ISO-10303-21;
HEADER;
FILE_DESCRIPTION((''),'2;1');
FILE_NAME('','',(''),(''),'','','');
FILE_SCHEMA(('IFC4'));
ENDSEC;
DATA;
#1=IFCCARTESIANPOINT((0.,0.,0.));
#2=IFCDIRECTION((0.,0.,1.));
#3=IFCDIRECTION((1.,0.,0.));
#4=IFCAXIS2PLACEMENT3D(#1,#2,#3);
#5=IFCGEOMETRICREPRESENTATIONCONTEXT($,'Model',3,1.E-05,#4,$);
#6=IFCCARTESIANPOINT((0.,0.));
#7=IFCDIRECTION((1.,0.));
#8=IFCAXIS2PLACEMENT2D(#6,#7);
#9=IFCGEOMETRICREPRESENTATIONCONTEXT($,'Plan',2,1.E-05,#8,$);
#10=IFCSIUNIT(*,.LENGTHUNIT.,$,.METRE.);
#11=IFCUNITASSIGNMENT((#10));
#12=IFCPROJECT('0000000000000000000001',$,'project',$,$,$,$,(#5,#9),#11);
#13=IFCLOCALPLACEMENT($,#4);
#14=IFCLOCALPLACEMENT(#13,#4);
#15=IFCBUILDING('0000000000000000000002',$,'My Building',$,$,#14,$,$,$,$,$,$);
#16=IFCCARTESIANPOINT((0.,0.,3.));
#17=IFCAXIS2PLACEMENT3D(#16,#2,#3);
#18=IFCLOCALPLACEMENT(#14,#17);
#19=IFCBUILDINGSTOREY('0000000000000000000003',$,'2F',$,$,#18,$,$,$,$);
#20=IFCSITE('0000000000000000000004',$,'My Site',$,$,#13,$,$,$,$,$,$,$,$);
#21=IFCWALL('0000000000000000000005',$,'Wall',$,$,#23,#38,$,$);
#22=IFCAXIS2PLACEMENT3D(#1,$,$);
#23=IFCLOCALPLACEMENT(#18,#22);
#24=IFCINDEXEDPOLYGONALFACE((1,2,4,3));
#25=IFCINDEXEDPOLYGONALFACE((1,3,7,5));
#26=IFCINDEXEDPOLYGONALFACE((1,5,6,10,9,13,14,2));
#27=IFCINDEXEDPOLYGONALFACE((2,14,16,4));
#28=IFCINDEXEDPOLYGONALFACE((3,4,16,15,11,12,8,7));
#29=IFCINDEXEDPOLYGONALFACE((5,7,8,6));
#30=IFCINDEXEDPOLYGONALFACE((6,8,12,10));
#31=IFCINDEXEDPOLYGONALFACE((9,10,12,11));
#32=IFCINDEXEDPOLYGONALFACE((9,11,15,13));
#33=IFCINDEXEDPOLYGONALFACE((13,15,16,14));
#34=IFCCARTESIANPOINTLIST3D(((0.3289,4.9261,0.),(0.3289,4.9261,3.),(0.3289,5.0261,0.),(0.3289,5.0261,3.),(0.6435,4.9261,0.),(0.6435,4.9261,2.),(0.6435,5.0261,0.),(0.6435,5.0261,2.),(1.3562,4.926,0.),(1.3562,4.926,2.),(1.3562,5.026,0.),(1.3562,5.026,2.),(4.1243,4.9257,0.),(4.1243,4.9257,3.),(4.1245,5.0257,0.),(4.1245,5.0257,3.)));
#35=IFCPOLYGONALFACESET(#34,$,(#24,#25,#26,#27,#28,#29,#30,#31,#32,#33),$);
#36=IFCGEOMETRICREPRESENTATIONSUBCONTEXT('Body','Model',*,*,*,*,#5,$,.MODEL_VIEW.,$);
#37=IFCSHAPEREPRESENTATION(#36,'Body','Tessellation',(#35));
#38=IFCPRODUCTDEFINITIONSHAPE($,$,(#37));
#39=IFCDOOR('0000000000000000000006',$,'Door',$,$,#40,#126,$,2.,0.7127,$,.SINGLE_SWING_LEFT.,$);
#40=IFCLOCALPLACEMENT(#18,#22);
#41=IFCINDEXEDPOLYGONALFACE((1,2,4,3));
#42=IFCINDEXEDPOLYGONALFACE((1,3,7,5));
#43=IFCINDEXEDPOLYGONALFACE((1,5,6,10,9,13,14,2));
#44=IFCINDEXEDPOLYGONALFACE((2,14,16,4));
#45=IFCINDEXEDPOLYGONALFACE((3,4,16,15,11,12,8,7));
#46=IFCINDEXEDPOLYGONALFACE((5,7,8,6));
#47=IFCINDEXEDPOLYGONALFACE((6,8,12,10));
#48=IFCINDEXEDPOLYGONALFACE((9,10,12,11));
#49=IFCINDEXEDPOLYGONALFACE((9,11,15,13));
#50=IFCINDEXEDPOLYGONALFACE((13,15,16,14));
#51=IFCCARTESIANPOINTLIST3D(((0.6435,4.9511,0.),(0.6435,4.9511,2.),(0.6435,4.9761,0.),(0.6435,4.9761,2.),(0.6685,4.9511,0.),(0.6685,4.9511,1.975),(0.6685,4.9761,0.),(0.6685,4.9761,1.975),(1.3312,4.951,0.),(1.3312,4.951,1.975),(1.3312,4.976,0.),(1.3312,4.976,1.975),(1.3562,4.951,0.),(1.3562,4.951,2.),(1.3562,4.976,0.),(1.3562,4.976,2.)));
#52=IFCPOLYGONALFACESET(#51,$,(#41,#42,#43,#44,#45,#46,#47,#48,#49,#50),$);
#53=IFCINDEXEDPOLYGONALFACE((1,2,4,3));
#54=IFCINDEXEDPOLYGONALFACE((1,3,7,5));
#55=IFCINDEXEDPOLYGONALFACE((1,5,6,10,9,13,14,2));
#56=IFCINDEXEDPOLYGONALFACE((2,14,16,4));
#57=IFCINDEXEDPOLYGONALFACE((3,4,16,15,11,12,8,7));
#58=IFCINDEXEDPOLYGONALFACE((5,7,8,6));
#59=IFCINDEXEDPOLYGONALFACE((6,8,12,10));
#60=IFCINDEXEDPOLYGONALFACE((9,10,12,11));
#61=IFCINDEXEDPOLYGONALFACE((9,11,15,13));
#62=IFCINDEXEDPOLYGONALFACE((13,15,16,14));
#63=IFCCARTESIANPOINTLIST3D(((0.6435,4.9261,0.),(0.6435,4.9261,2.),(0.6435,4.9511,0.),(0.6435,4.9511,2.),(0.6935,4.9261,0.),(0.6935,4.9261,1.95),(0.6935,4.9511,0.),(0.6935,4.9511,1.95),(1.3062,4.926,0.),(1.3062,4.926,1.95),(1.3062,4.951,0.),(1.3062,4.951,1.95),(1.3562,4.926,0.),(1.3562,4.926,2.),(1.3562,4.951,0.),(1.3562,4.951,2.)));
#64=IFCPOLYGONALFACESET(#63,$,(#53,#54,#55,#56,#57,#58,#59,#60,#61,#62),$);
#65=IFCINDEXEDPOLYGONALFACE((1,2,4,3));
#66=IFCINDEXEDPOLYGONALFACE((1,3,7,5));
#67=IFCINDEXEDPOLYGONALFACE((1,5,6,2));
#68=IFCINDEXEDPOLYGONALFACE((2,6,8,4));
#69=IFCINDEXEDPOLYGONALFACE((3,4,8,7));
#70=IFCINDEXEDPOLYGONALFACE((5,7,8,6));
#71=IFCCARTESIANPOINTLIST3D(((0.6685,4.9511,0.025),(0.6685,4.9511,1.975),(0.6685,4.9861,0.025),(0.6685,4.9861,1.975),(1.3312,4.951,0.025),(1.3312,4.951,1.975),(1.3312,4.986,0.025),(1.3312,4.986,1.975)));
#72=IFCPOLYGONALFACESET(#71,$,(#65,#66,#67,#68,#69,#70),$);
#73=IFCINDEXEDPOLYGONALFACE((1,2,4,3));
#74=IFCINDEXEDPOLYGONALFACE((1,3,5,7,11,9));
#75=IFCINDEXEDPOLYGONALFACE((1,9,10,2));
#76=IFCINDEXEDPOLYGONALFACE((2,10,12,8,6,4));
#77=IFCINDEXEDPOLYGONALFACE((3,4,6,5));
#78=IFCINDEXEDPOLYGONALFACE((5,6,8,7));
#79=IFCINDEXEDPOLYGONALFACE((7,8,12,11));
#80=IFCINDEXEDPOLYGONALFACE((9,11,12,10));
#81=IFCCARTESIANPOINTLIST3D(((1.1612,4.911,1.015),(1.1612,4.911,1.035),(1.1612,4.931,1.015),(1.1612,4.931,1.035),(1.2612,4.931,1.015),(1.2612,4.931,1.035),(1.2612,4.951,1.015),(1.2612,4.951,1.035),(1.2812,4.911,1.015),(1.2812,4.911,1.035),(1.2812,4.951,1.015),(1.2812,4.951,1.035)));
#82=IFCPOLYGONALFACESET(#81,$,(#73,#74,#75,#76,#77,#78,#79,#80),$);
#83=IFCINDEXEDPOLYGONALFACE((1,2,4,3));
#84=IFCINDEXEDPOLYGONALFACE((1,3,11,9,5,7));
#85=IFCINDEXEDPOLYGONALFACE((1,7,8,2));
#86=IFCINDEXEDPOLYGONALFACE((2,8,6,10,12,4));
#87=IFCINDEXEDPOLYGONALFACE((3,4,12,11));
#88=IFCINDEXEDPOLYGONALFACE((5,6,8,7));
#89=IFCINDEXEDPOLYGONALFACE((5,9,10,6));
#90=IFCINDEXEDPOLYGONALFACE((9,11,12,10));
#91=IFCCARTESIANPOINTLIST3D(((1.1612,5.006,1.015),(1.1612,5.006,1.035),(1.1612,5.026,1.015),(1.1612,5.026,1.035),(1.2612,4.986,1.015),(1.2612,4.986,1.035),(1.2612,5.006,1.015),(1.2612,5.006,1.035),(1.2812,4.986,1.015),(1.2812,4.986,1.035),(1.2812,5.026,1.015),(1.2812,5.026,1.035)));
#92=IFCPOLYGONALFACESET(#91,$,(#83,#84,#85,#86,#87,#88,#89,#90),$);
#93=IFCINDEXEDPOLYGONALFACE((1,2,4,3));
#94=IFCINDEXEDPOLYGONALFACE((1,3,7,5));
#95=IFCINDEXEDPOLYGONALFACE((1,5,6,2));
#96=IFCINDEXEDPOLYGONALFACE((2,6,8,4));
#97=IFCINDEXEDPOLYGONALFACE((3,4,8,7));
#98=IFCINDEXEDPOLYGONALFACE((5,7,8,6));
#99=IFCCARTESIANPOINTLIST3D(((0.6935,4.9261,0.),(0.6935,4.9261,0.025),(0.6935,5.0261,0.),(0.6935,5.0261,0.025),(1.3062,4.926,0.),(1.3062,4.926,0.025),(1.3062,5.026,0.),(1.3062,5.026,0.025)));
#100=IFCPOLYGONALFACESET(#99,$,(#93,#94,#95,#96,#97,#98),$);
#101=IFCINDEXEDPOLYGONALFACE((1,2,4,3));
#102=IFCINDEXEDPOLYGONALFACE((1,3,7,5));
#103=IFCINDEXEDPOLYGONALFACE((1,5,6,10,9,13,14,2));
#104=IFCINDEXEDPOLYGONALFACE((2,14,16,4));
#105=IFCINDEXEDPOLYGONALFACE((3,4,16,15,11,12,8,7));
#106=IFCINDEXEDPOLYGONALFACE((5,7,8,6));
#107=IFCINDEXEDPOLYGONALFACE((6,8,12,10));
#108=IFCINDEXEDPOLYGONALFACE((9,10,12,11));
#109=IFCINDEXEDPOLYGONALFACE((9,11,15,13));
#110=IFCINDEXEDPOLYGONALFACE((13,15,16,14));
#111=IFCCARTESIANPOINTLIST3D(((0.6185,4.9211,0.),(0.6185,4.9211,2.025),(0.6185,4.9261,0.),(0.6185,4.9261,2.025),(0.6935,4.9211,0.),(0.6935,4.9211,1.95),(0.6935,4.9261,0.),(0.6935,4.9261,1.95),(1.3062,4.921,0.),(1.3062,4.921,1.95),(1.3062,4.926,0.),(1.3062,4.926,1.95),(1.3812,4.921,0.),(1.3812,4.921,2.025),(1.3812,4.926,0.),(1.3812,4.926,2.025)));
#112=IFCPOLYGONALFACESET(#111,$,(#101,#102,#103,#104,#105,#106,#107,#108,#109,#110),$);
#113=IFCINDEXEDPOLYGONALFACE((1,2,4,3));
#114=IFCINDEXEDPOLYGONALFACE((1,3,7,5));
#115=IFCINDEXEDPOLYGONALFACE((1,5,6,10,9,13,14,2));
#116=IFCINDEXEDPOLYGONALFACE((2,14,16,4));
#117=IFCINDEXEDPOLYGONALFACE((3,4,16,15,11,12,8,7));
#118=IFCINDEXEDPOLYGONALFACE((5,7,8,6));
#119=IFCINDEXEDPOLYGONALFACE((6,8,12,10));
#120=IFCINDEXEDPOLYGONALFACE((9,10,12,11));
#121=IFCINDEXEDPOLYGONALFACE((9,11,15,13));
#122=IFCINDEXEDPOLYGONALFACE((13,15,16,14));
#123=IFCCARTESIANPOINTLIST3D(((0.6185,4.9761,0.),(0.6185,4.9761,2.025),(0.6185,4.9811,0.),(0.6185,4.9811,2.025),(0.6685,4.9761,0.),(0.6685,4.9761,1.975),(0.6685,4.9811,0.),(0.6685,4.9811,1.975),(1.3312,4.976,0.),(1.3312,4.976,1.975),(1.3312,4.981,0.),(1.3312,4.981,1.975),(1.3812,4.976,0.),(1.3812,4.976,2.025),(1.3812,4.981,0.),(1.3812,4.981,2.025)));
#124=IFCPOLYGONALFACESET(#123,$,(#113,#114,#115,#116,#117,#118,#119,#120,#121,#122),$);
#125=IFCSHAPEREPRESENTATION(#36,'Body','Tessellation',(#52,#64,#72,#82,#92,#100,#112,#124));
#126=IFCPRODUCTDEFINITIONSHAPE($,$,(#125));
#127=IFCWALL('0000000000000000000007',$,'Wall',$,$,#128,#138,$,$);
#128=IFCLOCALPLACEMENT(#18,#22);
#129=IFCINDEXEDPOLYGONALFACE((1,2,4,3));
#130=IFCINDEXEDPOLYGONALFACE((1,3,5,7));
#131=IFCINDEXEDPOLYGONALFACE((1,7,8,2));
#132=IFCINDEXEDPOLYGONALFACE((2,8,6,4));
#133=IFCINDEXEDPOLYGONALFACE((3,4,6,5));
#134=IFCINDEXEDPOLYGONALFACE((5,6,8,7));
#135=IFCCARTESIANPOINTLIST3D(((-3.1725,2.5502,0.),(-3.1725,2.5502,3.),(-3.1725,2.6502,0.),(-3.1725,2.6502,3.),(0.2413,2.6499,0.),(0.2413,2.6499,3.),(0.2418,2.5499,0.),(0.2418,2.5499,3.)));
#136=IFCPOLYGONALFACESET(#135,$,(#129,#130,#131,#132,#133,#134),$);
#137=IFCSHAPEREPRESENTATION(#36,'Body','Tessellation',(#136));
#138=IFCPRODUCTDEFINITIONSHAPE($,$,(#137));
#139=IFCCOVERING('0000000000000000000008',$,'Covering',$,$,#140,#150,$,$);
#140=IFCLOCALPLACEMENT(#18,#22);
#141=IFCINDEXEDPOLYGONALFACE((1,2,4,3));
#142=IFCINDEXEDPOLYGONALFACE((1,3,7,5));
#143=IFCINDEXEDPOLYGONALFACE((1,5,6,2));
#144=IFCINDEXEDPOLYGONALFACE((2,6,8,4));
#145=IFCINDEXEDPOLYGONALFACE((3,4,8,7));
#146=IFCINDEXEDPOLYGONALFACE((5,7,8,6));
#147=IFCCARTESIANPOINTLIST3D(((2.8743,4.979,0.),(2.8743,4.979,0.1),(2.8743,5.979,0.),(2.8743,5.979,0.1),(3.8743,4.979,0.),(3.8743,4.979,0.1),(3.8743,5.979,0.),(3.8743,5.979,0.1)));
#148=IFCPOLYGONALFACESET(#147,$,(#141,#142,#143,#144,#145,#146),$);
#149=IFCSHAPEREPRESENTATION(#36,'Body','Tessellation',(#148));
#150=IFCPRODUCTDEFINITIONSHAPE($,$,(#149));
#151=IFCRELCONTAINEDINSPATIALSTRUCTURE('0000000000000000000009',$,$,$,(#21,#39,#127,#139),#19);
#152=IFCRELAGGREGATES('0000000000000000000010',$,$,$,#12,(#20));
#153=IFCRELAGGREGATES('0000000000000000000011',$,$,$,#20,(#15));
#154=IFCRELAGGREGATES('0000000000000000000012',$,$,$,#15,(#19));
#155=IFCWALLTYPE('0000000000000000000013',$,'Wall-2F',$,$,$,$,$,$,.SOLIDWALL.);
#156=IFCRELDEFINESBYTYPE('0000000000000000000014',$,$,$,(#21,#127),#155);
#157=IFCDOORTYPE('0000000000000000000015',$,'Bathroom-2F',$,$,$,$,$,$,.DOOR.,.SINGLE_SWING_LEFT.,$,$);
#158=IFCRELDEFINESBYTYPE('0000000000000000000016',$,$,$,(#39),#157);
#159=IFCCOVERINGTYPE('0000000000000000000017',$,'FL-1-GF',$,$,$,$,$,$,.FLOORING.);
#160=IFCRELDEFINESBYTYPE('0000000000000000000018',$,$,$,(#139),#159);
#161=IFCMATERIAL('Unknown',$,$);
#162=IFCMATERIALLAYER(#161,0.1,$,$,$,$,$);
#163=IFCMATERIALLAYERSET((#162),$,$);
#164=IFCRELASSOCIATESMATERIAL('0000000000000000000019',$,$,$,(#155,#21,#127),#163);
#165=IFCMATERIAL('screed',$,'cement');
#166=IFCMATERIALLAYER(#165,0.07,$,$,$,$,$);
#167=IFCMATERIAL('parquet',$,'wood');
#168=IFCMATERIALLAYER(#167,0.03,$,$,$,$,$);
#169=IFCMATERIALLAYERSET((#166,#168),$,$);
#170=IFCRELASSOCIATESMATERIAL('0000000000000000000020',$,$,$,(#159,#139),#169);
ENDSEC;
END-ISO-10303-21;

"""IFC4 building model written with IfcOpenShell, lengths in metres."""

from ifc_helpers import new_model, entity, si_unit, frame, origin_with_axes, origin_2d_with_axis, place, context, subcontext, project, spatial, line, indexed_curve, outline, extrude, shape, source, transform, mapped, material, layer, layer_set, layer_usage, type_object, type_shapes, element, fill, save


model = new_model("IFC4")

# Units and contexts
model_context = context("Model", 3, precision=1e-05, world=origin_with_axes())
plan_context = context("Plan", 2, precision=1e-05, world=origin_2d_with_axis())
body_context_1 = subcontext(model_context, "Body", "Model", "MODEL_VIEW")
body_context_2 = subcontext(plan_context, "Body", "Plan", "PLAN_VIEW")
ifc_project = project(units=[si_unit("LENGTHUNIT", "METRE")], contexts=[model_context, plan_context])

# Site, building, storey
site_placement = place(None, origin_with_axes())
site = spatial("IfcSite", under=ifc_project, at=site_placement, Name="My Site")
building_placement = place(site_placement, origin_with_axes())
building = spatial("IfcBuilding", under=site, at=building_placement, Name="My Building")
storey_placement = place(building_placement, frame((0.0, 0.0, 3.0), z_axis=(0.0, 0.0, 1.0), x_axis=(1.0, 0.0, 0.0)))
storey = spatial("IfcBuildingStorey", under=building, at=storey_placement, Name="2F")

# Shared definitions
ifc_material_1 = material(Name="Unknown")

# Shared definitions
ifc_layer_1 = layer(ifc_material_1, 0.1)
ifc_layer_set_1 = layer_set([ifc_layer_1])
wall_type = type_object("IfcWallType", Name="Wall-2F", PredefinedType="SOLIDWALL", material=ifc_layer_set_1)

# Wall, opening, door
ifc_layer_usage_1 = layer_usage(ifc_layer_set_1, "AXIS2", "POSITIVE", 0.0)
wall_1_placement = place(storey_placement, frame((0.3289, 4.9261, 0.0), z_axis=(0.0, 0.0, 1.0), x_axis=(1.0, -0.000101, 0.0)))
wall_1 = element("IfcWall", 1, at=wall_1_placement, inside=storey, type_object=wall_type, material=ifc_layer_usage_1, Name="Wall", context=body_context_1, shape_type="SweptSolid", body=[
    extrude(outline(indexed_curve([(0.0, 0.0), (0.0, 0.1), (3.7955, 0.1), (3.7954, 0.0)], segments=[line(1, 2, 3, 4, 1)])), origin_with_axes(), (0.0, 0.0, 1.0), 3.0),
])
shared_shape_1 = source(origin_with_axes(), body_context_1, "Body", "SweptSolid", [
    extrude(outline(indexed_curve([(0.0, 0.0), (0.7127, 0.0), (0.7127, 2.0), (0.0, 2.0)], segments=[line(1, 2, 3, 4, 1)])), frame((0.0, -0.6, 0.0), z_axis=(0.0, -1.0, 0.0), x_axis=(1.0, 0.0, 0.0)), (0.0, 0.0, -1.0), 1.2),
])
opening_1_placement = place(wall_1_placement, frame((0.3146, 0.0, 0.0), z_axis=(0.0, 0.0, 1.0), x_axis=(1.0, 0.0, 0.0)))
opening_1 = element("IfcOpeningElement", 2, at=opening_1_placement, cuts=wall_1, PredefinedType="OPENING", context=body_context_1, shape_type="MappedRepresentation", body=[
    mapped(shared_shape_1, transform((0.0, 0.0, 0.0), x_axis=(1.0, 0.0, 0.0), y_axis=(0.0, 1.0, 0.0), z_axis=(0.0, 0.0, 1.0), scale=1.0)),
])
door_type = type_object("IfcDoorType", Name="Bathroom-2F", OperationType="SINGLE_SWING_LEFT", PredefinedType="DOOR")
shared_shape_2 = source(origin_with_axes(), body_context_1, "Body", "SweptSolid", [
    extrude(outline(indexed_curve([(0.0, 0.0), (0.0, 2.0), (0.7127, 2.0), (0.7127, 0.0), (0.6877, 0.0), (0.6877, 1.975), (0.025, 1.975), (0.025, 0.0)], segments=[line(1, 2, 3, 4, 5, 6, 7, 8, 1)])), frame((0.0, 0.025, 0.0), z_axis=(0.0, -1.0, 0.0), x_axis=(1.0, 0.0, 0.0)), (0.0, 0.0, -1.0), 0.025),
    extrude(outline(indexed_curve([(0.0, 0.0), (0.0, 2.0), (0.7127, 2.0), (0.7127, 0.0), (0.6627, 0.0), (0.6627, 1.95), (0.05, 1.95), (0.05, 0.0)], segments=[line(1, 2, 3, 4, 5, 6, 7, 8, 1)])), frame((0.0, 0.0, 0.0), z_axis=(0.0, -1.0, 0.0), x_axis=(1.0, 0.0, 0.0)), (0.0, 0.0, -1.0), 0.025),
    extrude(outline(indexed_curve([(0.0, 0.0), (0.6627, 0.0), (0.6627, 0.035), (0.0, 0.035)], segments=[line(1, 2, 3, 4, 1)])), frame((0.025, 0.025, 0.025), z_axis=(0.0, 0.0, 1.0), x_axis=(1.0, 0.0, 0.0)), (0.0, 0.0, 1.0), 1.95),
    extrude(outline(indexed_curve([(0.0, 0.0), (0.0, -0.04), (-0.12, -0.04), (-0.12, -0.02), (-0.02, -0.02), (-0.02, 0.0)], segments=[line(1, 2, 3, 4, 5, 6, 1)])), frame((0.6377, 0.025, 1.015), z_axis=(0.0, 0.0, 1.0), x_axis=(1.0, 0.0, 0.0)), (0.0, 0.0, 1.0), 0.02),
    extrude(outline(indexed_curve([(0.0, 0.0), (0.0, 0.04), (-0.12, 0.04), (-0.12, 0.02), (-0.02, 0.02), (-0.02, 0.0)], segments=[line(1, 2, 3, 4, 5, 6, 1)])), frame((0.6377, 0.06, 1.015), z_axis=(0.0, 0.0, 1.0), x_axis=(1.0, 0.0, 0.0)), (0.0, 0.0, 1.0), 0.02),
    extrude(outline(indexed_curve([(0.0, 0.0), (0.6127, 0.0), (0.6127, 0.1), (0.0, 0.1)], segments=[line(1, 2, 3, 4, 1)])), frame((0.05, 0.0, 0.0), z_axis=(0.0, 0.0, 1.0), x_axis=(1.0, 0.0, 0.0)), (0.0, 0.0, 1.0), 0.025),
    extrude(outline(indexed_curve([(0.0, 0.0), (0.0, 2.025), (0.7627, 2.025), (0.7627, 0.0), (0.6877, 0.0), (0.6877, 1.95), (0.075, 1.95), (0.075, 0.0)], segments=[line(1, 2, 3, 4, 5, 6, 7, 8, 1)])), frame((-0.025, -0.005, 0.0), z_axis=(0.0, -1.0, 0.0), x_axis=(1.0, 0.0, 0.0)), (0.0, 0.0, -1.0), 0.005),
    extrude(outline(indexed_curve([(0.0, 0.0), (0.0, 2.025), (0.7627, 2.025), (0.7627, 0.0), (0.7127, 0.0), (0.7127, 1.975), (0.05, 1.975), (0.05, 0.0)], segments=[line(1, 2, 3, 4, 5, 6, 7, 8, 1)])), frame((-0.025, 0.05, 0.0), z_axis=(0.0, -1.0, 0.0), x_axis=(1.0, 0.0, 0.0)), (0.0, 0.0, -1.0), 0.005),
])
shared_shape_3 = source(origin_with_axes(), body_context_2, "Body", "Curve2D", [
    entity("IfcIndexedPolyCurve", entity("IfcCartesianPointList2D", [[0.0, 0.0], [0.0, 0.05], [0.025, 0.05], [0.025, 0.025], [0.05, 0.025], [0.05, 0.0]]), [entity("IfcLineIndex", [1, 2, 3, 4, 5, 6, 1])]),
    entity("IfcIndexedPolyCurve", entity("IfcCartesianPointList2D", [[0.7127, 0.0], [0.7127, 0.05], [0.6877, 0.05], [0.6877, 0.025], [0.6627, 0.025], [0.6627, 0.0]]), [entity("IfcLineIndex", [1, 2, 3, 4, 5, 6, 1])]),
    entity("IfcTrimmedCurve", entity("IfcEllipse", entity("IfcAxis2Placement2D", entity("IfcCartesianPoint", [0.06, 0.05]), entity("IfcDirection", [1.0, 0.0])), 0.6277, 0.6627), [entity("IfcCartesianPoint", [0.6877, 0.05])], [entity("IfcCartesianPoint", [0.06, 0.7127])], True, "CARTESIAN"),
    entity("IfcIndexedPolyCurve", entity("IfcCartesianPointList2D", [[0.025, 0.05], [0.06, 0.05], [0.06, 0.7127], [0.025, 0.7127]]), [entity("IfcLineIndex", [1, 2, 3, 4, 1])]),
])
type_shapes(door_type, [shared_shape_2, shared_shape_3])
door_placement = place(opening_1_placement, frame((0.0, 0.0, 0.0), z_axis=(0.0, 0.0, 1.0), x_axis=(1.0, 0.0, 0.0)))
door = element("IfcDoor", 3, at=door_placement, inside=storey, type_object=door_type, Name="Door", OperationType="SINGLE_SWING_LEFT", OverallHeight=2.0, OverallWidth=0.7127, shapes=[
    shape(body_context_1, "Body", "MappedRepresentation", [mapped(shared_shape_2, transform((0.0, 0.0, 0.0), x_axis=(1.0, 0.0, 0.0), y_axis=(0.0, 1.0, 0.0), z_axis=(0.0, 0.0, 1.0), scale=1.0))]),
    shape(body_context_2, "Body", "MappedRepresentation", [mapped(shared_shape_3, transform((0.0, 0.0, 0.0), x_axis=(1.0, 0.0, 0.0), y_axis=(0.0, 1.0, 0.0), z_axis=(0.0, 0.0, 1.0), scale=1.0))]),
])
fill(opening_1, door)

# Wall
ifc_layer_usage_2 = layer_usage(ifc_layer_set_1, "AXIS2", "POSITIVE", 0.0)
wall_2_placement = place(storey_placement, frame((-3.1725, 2.5502, 0.0), z_axis=(0.0, 0.0, 1.0), x_axis=(1.0, -0.000076, 0.0)))
element("IfcWall", 4, at=wall_2_placement, inside=storey, type_object=wall_type, material=ifc_layer_usage_2, Name="Wall", context=body_context_1, shape_type="SweptSolid", body=[
    extrude(outline(indexed_curve([(0.0, 0.0), (0.0, 0.1), (3.4138, 0.1), (3.4144, 0.0)], segments=[line(1, 2, 3, 4, 1)])), origin_with_axes(), (0.0, 0.0, 1.0), 3.0),
])

# Covering
ifc_material_2 = material(Name="screed", Category="cement")
ifc_layer_2 = layer(ifc_material_2, 0.07)
ifc_material_3 = material(Name="parquet", Category="wood")
ifc_layer_3 = layer(ifc_material_3, 0.03)
ifc_layer_set_2 = layer_set([ifc_layer_2, ifc_layer_3])
ifc_layer_usage_3 = layer_usage(ifc_layer_set_2, "AXIS3", "POSITIVE", 0.0)
covering_type = type_object("IfcCoveringType", Name="FL-1-GF", PredefinedType="FLOORING", material=ifc_layer_set_2)
covering_1_placement = place(storey_placement, frame((2.8743, 4.979, 0.0), z_axis=(0.0, 0.0, 1.0), x_axis=(1.0, 0.0, 0.0)))
element("IfcCovering", 5, at=covering_1_placement, inside=storey, type_object=covering_type, material=ifc_layer_usage_3, Name="Covering", context=body_context_1, shape_type="SweptSolid", body=[
    extrude(outline(indexed_curve([(0.0, 0.0), (1.0, 0.0), (1.0, 1.0), (0.0, 1.0), (0.0, 0.0)])), origin_with_axes(), (0.0, 0.0, 1.0), 0.1),
])

save(model, "model.ifc")
